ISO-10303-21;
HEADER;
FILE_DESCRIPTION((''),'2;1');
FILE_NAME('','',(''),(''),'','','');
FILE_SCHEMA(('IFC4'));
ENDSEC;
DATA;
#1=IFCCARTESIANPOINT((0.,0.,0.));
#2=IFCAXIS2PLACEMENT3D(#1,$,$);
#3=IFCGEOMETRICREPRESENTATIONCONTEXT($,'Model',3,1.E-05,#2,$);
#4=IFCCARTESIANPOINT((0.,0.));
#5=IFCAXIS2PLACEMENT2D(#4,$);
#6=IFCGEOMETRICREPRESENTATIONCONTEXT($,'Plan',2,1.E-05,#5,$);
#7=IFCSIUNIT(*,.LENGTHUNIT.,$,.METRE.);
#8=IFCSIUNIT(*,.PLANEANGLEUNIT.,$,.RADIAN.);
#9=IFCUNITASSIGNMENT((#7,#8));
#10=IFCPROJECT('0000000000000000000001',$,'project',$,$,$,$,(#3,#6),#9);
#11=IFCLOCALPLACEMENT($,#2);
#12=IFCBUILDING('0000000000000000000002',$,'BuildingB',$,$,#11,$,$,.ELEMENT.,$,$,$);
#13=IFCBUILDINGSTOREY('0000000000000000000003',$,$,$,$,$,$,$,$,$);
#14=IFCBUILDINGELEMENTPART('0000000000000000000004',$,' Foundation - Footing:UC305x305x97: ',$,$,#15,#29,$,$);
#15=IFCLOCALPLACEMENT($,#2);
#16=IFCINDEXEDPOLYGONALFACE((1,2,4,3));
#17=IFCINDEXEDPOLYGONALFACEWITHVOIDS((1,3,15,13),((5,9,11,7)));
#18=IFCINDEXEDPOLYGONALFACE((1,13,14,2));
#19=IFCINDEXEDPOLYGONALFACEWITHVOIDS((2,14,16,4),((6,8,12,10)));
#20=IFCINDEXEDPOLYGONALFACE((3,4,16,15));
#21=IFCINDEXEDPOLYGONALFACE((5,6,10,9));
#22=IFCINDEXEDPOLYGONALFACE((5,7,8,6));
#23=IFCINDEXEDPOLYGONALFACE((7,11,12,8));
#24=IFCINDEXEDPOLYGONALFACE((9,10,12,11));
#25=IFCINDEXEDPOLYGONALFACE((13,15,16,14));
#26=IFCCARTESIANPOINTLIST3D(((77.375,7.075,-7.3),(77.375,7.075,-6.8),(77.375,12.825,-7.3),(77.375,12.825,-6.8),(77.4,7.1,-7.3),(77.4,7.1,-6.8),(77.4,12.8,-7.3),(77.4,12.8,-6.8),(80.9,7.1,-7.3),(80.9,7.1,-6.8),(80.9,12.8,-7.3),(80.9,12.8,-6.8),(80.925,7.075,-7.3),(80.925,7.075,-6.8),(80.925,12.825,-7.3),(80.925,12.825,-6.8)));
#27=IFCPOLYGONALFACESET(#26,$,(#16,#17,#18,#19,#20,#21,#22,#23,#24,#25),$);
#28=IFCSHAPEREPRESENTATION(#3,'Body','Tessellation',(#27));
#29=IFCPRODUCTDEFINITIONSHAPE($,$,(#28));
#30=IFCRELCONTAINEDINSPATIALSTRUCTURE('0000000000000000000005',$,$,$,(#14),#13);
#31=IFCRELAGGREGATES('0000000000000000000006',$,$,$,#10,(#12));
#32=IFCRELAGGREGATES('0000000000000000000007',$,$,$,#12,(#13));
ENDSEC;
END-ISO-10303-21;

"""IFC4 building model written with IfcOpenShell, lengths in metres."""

from ifc_helpers import new_model, si_unit, origin, origin_2d, place, context, project, spatial, polyline, outline, extrude, element, save


model = new_model("IFC4")

# Units and contexts
model_context = context("Model", 3, precision=1e-05, world=origin())
plan_context = context("Plan", 2, precision=1e-05, world=origin_2d())
ifc_project = project(units=[si_unit("LENGTHUNIT", "METRE"), si_unit("PLANEANGLEUNIT", "RADIAN")], contexts=[model_context, plan_context])

# Building, storey
building_placement = place(None, origin())
building = spatial("IfcBuilding", under=ifc_project, at=building_placement, Name="BuildingB", CompositionType="ELEMENT")
storey = spatial("IfcBuildingStorey", under=building)

# Building element part, opening
building_element_part_1 = element("IfcBuildingElementPart", 1, inside=storey, Name=" Foundation - Footing:UC305x305x97: ", context=model_context, shape_type="SweptSolid", body=[
    extrude(outline(polyline([(77.375, 12.825, -7.3), (80.925, 12.825, -7.3), (80.925, 7.075, -7.3), (77.375, 7.075, -7.3), (77.375, 12.825, -7.3)])), None, (0.0, 0.0, 1.0), 0.5),
])
element("IfcOpeningElement", 2, inside=storey, cuts=building_element_part_1, context=model_context, shape_type="SweptSolid", body=[
    extrude(outline(polyline([(77.4, 12.8, -7.3), (80.9, 12.8, -7.3), (80.9, 7.1, -7.3), (77.4, 7.1, -7.3), (77.4, 12.8, -7.3)])), None, (0.0, 0.0, 1.0), 0.5),
])

save(model, "model.ifc")
